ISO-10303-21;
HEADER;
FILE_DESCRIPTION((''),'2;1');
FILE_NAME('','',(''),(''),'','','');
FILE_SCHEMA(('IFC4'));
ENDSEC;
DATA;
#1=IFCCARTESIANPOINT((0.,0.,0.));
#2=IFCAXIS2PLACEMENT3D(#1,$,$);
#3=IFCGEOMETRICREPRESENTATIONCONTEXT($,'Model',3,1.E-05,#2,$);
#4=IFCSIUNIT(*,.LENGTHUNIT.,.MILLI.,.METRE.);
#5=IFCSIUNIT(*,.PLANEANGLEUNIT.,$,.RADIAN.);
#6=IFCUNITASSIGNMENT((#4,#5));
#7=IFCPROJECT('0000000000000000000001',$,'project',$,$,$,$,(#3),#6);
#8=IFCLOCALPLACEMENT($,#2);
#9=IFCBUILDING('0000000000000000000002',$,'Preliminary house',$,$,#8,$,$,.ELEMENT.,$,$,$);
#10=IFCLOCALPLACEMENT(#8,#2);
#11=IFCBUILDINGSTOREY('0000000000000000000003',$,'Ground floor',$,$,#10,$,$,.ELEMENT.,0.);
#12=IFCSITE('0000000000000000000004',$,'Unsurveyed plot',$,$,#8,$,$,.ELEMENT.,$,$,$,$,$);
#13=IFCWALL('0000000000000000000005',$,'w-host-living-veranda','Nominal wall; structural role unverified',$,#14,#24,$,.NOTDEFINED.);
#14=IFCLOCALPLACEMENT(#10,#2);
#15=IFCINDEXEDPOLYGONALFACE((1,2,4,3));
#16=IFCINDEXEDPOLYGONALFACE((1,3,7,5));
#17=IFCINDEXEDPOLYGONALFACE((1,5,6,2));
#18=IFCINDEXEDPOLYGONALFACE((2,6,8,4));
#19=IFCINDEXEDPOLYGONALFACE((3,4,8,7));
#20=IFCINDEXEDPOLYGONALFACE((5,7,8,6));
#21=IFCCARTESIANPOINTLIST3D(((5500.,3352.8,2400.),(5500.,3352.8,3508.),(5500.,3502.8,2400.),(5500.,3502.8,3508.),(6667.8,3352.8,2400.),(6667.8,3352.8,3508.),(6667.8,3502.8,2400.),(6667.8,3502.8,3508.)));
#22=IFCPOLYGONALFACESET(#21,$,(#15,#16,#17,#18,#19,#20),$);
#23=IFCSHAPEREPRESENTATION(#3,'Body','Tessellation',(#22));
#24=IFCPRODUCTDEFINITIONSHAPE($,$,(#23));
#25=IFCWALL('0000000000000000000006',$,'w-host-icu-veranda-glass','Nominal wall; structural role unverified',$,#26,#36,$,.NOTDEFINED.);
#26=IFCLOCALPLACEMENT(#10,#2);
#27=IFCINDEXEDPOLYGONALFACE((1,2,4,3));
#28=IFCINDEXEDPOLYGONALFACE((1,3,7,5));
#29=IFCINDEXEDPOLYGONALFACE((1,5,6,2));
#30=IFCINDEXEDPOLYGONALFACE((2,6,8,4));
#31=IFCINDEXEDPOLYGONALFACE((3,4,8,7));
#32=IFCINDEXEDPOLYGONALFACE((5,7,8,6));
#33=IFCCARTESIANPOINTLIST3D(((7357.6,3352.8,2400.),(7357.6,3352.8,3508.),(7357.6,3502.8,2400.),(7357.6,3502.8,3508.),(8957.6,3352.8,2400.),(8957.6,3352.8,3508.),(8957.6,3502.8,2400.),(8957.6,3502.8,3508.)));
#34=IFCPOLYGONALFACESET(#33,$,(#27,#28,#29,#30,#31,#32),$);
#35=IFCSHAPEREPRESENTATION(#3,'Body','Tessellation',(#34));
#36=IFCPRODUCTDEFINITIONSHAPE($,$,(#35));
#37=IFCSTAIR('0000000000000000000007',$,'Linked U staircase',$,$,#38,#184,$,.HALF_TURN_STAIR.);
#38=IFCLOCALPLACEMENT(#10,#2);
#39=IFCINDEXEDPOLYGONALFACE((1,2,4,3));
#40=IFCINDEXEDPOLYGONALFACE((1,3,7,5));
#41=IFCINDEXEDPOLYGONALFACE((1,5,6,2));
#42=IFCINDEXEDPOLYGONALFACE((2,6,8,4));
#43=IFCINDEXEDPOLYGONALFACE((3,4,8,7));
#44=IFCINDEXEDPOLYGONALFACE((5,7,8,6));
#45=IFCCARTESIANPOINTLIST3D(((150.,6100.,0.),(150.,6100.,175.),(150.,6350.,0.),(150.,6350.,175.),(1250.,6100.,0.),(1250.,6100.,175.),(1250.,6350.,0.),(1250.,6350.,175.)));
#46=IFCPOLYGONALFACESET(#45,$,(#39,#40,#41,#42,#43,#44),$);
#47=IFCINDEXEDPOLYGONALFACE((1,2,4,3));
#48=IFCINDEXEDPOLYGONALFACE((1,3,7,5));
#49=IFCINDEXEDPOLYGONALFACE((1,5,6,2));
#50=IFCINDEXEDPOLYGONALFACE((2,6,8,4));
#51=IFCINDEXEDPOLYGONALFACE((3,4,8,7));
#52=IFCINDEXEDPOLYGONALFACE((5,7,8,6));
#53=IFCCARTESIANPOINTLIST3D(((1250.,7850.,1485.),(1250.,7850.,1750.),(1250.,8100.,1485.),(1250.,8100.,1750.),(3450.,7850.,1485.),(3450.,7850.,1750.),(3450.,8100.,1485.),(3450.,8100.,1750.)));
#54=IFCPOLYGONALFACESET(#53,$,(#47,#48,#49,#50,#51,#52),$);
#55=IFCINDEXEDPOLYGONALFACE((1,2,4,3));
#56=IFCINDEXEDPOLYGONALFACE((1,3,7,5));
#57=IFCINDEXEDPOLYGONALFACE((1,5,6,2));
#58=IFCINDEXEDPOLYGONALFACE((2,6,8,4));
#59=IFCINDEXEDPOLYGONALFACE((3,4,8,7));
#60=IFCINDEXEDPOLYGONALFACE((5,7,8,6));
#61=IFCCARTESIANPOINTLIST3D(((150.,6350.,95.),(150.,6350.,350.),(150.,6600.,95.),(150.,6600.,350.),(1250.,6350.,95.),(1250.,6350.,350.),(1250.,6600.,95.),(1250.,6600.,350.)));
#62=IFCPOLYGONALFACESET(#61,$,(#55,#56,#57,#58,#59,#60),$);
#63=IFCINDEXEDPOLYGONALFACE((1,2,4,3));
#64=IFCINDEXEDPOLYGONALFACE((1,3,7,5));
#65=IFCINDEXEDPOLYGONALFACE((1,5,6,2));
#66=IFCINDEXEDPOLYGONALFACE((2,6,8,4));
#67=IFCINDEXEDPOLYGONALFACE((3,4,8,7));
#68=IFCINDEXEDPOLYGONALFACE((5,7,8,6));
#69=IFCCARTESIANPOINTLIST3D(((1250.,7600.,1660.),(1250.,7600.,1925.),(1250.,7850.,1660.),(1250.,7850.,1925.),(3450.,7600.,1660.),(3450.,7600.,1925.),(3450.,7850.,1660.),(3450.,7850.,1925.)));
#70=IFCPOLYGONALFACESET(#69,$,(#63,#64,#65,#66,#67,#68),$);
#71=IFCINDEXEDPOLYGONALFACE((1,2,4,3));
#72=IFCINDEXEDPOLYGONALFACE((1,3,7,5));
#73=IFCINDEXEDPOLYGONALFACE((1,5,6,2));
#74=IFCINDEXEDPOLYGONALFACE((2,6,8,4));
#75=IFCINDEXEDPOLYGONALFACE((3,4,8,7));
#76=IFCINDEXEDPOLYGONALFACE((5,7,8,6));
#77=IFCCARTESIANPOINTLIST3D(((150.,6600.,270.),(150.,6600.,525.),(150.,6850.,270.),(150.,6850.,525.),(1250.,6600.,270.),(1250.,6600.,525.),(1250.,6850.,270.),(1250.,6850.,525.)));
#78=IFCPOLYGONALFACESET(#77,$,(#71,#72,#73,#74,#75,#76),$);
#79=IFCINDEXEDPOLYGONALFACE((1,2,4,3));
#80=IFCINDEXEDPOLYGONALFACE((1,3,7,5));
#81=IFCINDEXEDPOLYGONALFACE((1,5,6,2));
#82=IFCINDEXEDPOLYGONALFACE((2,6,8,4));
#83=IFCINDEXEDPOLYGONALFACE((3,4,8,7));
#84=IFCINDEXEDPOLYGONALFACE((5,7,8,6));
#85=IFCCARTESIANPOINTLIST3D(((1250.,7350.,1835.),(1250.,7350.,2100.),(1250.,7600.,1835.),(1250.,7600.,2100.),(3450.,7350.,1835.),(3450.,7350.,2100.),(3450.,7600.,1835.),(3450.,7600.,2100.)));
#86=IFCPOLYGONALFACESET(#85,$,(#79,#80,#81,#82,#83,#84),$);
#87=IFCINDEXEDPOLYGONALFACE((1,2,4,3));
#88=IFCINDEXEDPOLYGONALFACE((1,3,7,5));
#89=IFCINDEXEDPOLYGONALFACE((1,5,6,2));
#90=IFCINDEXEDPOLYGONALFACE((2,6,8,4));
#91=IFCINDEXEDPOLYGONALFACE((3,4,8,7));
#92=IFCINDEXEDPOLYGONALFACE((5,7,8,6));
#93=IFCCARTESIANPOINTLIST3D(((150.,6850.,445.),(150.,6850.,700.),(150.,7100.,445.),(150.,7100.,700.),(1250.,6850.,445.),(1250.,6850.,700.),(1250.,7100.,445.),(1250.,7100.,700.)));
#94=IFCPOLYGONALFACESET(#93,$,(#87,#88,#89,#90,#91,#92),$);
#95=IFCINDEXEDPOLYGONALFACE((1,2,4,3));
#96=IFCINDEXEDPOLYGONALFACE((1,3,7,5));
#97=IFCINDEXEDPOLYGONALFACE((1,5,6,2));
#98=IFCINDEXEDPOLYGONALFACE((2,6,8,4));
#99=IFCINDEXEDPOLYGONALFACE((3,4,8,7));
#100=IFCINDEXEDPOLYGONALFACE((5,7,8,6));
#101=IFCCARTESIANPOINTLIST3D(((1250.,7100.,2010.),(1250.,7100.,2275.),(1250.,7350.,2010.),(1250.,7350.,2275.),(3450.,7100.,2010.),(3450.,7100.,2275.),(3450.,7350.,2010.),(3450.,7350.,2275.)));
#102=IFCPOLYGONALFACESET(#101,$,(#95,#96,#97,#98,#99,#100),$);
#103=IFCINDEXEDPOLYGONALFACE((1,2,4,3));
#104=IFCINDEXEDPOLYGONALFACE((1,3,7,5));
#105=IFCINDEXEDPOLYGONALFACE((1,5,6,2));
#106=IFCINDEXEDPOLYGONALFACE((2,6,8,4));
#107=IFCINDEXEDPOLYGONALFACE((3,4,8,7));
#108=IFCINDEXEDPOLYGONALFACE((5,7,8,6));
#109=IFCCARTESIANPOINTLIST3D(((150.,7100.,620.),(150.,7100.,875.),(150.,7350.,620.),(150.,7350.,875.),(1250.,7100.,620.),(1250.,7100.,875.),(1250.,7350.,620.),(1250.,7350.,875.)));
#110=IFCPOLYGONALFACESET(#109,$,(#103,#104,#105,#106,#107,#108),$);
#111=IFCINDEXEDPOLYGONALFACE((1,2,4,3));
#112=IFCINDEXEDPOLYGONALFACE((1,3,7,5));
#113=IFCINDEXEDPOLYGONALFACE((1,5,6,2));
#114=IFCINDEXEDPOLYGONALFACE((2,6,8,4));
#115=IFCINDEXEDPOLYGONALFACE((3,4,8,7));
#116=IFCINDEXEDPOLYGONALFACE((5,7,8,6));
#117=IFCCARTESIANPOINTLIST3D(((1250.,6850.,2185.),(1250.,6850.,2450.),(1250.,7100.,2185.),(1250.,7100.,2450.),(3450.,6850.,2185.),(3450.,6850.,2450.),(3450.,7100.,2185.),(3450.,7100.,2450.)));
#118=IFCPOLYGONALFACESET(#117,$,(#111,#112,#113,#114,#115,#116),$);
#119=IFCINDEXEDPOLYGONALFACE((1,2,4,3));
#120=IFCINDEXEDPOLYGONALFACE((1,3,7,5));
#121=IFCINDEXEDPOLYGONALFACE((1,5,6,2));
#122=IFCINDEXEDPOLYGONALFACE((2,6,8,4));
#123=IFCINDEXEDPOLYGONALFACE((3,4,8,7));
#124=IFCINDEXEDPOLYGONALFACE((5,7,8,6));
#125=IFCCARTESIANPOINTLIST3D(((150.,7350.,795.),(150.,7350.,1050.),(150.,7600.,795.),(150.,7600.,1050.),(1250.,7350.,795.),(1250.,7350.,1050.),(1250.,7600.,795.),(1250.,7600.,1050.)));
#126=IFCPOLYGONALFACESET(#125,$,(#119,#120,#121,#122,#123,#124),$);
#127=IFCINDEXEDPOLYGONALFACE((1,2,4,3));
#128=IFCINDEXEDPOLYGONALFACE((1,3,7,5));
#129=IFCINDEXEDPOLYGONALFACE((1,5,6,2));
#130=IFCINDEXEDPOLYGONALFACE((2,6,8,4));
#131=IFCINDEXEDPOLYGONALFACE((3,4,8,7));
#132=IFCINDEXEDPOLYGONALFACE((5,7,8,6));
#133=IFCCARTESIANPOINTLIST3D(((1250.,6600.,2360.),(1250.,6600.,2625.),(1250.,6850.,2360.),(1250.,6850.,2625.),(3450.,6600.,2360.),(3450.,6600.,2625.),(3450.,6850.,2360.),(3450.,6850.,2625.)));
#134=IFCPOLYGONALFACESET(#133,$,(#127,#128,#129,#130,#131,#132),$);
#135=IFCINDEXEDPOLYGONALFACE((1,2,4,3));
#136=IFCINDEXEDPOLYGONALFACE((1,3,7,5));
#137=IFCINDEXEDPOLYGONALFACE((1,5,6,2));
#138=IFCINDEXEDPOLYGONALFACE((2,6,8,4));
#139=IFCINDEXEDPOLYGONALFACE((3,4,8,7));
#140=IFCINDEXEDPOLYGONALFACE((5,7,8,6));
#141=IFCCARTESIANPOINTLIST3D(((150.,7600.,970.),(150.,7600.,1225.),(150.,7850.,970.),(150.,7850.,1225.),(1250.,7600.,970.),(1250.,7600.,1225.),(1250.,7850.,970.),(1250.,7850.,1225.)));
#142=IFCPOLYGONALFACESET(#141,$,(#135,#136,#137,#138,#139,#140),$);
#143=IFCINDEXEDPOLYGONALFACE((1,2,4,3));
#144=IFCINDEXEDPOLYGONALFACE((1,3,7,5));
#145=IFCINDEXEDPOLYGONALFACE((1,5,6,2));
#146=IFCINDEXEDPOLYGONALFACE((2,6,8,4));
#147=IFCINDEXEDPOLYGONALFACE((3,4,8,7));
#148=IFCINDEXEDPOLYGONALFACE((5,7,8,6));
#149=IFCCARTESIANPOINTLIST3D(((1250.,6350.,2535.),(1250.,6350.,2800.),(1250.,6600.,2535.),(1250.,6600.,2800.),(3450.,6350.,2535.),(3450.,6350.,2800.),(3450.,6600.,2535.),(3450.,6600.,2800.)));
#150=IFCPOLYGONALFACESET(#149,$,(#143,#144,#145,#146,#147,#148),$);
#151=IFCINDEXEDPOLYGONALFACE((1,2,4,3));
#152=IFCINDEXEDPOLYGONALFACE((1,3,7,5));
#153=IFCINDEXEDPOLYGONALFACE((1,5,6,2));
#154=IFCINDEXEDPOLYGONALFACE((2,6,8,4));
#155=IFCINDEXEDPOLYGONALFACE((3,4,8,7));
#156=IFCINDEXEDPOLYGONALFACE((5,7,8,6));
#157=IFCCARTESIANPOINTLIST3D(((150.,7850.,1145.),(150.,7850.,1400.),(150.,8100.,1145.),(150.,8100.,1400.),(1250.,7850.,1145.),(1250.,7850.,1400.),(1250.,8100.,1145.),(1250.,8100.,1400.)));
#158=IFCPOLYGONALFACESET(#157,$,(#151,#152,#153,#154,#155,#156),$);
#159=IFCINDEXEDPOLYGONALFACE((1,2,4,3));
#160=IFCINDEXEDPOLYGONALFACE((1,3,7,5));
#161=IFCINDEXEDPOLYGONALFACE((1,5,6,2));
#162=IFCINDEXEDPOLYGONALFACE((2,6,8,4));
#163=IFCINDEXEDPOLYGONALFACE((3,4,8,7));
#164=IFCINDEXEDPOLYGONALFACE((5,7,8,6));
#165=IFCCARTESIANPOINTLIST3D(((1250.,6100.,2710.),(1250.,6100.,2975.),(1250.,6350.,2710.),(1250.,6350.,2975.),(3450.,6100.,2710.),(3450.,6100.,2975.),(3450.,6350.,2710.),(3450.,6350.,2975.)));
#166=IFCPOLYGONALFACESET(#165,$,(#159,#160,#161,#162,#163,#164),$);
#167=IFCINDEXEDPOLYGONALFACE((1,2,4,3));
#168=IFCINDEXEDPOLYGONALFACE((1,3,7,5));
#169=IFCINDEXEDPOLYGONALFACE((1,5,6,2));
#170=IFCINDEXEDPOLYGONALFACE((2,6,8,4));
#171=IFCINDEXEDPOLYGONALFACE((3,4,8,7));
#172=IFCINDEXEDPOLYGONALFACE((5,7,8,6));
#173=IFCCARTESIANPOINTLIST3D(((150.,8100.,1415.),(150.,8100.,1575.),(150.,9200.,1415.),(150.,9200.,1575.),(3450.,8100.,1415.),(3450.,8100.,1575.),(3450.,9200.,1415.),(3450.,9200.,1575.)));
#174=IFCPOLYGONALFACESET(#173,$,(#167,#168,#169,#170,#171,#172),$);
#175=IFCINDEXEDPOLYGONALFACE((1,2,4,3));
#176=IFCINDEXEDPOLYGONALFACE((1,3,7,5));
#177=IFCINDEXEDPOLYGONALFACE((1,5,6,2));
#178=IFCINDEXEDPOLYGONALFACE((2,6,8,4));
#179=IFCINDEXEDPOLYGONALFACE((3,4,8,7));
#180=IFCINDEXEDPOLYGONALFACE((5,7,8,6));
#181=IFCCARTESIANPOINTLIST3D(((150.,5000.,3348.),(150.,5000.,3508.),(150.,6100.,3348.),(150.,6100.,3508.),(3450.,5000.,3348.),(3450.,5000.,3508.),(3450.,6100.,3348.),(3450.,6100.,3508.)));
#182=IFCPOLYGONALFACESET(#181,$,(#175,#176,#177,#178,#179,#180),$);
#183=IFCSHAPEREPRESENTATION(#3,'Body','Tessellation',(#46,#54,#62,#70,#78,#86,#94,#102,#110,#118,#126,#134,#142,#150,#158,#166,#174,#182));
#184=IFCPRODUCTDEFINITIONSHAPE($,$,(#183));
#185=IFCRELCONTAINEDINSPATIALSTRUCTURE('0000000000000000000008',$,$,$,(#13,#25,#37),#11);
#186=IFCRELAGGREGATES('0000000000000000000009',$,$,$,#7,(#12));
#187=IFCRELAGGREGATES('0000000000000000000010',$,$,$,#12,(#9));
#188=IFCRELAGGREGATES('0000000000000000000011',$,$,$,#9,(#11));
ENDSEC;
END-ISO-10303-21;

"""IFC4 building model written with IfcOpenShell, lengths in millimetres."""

from ifc_helpers import new_model, si_unit, frame, origin, place, context, project, spatial, polyline, outline, extrude, element, save


model = new_model("IFC4")

# Units and contexts
model_context = context("Model", 3, precision=1e-05, world=origin())
ifc_project = project(units=[si_unit("LENGTHUNIT", "METRE", prefix="MILLI"), si_unit("PLANEANGLEUNIT", "RADIAN")], contexts=[model_context])

# Site, building, storey
placement_1 = place(None, origin())
site = spatial("IfcSite", under=ifc_project, at=placement_1, Name="Unsurveyed plot", CompositionType="ELEMENT")
building = spatial("IfcBuilding", under=site, at=placement_1, Name="Preliminary house", CompositionType="ELEMENT")
placement_2 = place(placement_1, origin())
storey = spatial("IfcBuildingStorey", under=building, at=placement_2, Name="Ground floor", CompositionType="ELEMENT", Elevation=0.0)

# Walls, openings
wall_1 = element("IfcWall", 1, at=placement_2, inside=storey, Name="w-host-living-veranda", Description="Nominal wall; structural role unverified", PredefinedType="NOTDEFINED", context=model_context, shape_type="SweptSolid", body=[
    extrude(outline(polyline([(5500.0, 3352.8), (6667.8, 3352.8), (6667.8, 3502.8), (5500.0, 3502.8), (5500.0, 3352.8)])), origin(), (0.0, 0.0, 1.0), 3508.0),
])
element("IfcOpeningElement", 2, at=placement_2, cuts=wall_1, PredefinedType="OPENING", context=model_context, shape_type="SweptSolid", body=[
    extrude(outline(polyline([(5500.0, 2977.8), (6667.8, 2977.8), (6667.8, 3877.8), (5500.0, 3877.8), (5500.0, 2977.8)])), origin(), (0.0, 0.0, 1.0), 2400.0),
])
wall_2 = element("IfcWall", 3, at=placement_2, inside=storey, Name="w-host-icu-veranda-glass", Description="Nominal wall; structural role unverified", PredefinedType="NOTDEFINED", context=model_context, shape_type="SweptSolid", body=[
    extrude(outline(polyline([(7357.6, 3352.8), (8957.6, 3352.8), (8957.6, 3502.8), (7357.6, 3502.8), (7357.6, 3352.8)])), origin(), (0.0, 0.0, 1.0), 3508.0),
])
element("IfcOpeningElement", 4, at=placement_2, cuts=wall_2, PredefinedType="OPENING", context=model_context, shape_type="SweptSolid", body=[
    extrude(outline(polyline([(7357.6, 2977.8), (8957.6, 2977.8), (8957.6, 3877.8), (7357.6, 3877.8), (7357.6, 2977.8)])), origin(), (0.0, 0.0, 1.0), 2400.0),
])

# Stair
element("IfcStair", 5, at=placement_2, inside=storey, Name="Linked U staircase", PredefinedType="HALF_TURN_STAIR", context=model_context, shape_type="SweptSolid", body=[
    extrude(outline(polyline([(1250.0, 6100.0), (1250.0, 6350.0), (150.0, 6350.0), (150.0, 6100.0), (1250.0, 6100.0)])), origin(), (0.0, 0.0, 1.0), 175.0),
    extrude(outline(polyline([(3450.0, 7850.0), (3450.0, 8100.0), (1250.0, 8100.0), (1250.0, 7850.0), (3450.0, 7850.0)])), frame((0.0, 0.0, 1485.0)), (0.0, 0.0, 1.0), 265.0),
    extrude(outline(polyline([(1250.0, 6350.0), (1250.0, 6600.0), (150.0, 6600.0), (150.0, 6350.0), (1250.0, 6350.0)])), frame((0.0, 0.0, 95.0)), (0.0, 0.0, 1.0), 255.0),
    extrude(outline(polyline([(3450.0, 7600.0), (3450.0, 7850.0), (1250.0, 7850.0), (1250.0, 7600.0), (3450.0, 7600.0)])), frame((0.0, 0.0, 1660.0)), (0.0, 0.0, 1.0), 265.0),
    extrude(outline(polyline([(1250.0, 6600.0), (1250.0, 6850.0), (150.0, 6850.0), (150.0, 6600.0), (1250.0, 6600.0)])), frame((0.0, 0.0, 270.0)), (0.0, 0.0, 1.0), 255.0),
    extrude(outline(polyline([(3450.0, 7350.0), (3450.0, 7600.0), (1250.0, 7600.0), (1250.0, 7350.0), (3450.0, 7350.0)])), frame((0.0, 0.0, 1835.0)), (0.0, 0.0, 1.0), 265.0),
    extrude(outline(polyline([(1250.0, 6850.0), (1250.0, 7100.0), (150.0, 7100.0), (150.0, 6850.0), (1250.0, 6850.0)])), frame((0.0, 0.0, 445.0)), (0.0, 0.0, 1.0), 255.0),
    extrude(outline(polyline([(3450.0, 7100.0), (3450.0, 7350.0), (1250.0, 7350.0), (1250.0, 7100.0), (3450.0, 7100.0)])), frame((0.0, 0.0, 2010.0)), (0.0, 0.0, 1.0), 265.0),
    extrude(outline(polyline([(1250.0, 7100.0), (1250.0, 7350.0), (150.0, 7350.0), (150.0, 7100.0), (1250.0, 7100.0)])), frame((0.0, 0.0, 620.0)), (0.0, 0.0, 1.0), 255.0),
    extrude(outline(polyline([(3450.0, 6850.0), (3450.0, 7100.0), (1250.0, 7100.0), (1250.0, 6850.0), (3450.0, 6850.0)])), frame((0.0, 0.0, 2185.0)), (0.0, 0.0, 1.0), 265.0),
    extrude(outline(polyline([(1250.0, 7350.0), (1250.0, 7600.0), (150.0, 7600.0), (150.0, 7350.0), (1250.0, 7350.0)])), frame((0.0, 0.0, 795.0)), (0.0, 0.0, 1.0), 255.0),
    extrude(outline(polyline([(3450.0, 6600.0), (3450.0, 6850.0), (1250.0, 6850.0), (1250.0, 6600.0), (3450.0, 6600.0)])), frame((0.0, 0.0, 2360.0)), (0.0, 0.0, 1.0), 265.0),
    extrude(outline(polyline([(1250.0, 7600.0), (1250.0, 7850.0), (150.0, 7850.0), (150.0, 7600.0), (1250.0, 7600.0)])), frame((0.0, 0.0, 970.0)), (0.0, 0.0, 1.0), 255.0),
    extrude(outline(polyline([(3450.0, 6350.0), (3450.0, 6600.0), (1250.0, 6600.0), (1250.0, 6350.0), (3450.0, 6350.0)])), frame((0.0, 0.0, 2535.0)), (0.0, 0.0, 1.0), 265.0),
    extrude(outline(polyline([(1250.0, 7850.0), (1250.0, 8100.0), (150.0, 8100.0), (150.0, 7850.0), (1250.0, 7850.0)])), frame((0.0, 0.0, 1145.0)), (0.0, 0.0, 1.0), 255.0),
    extrude(outline(polyline([(3450.0, 6100.0), (3450.0, 6350.0), (1250.0, 6350.0), (1250.0, 6100.0), (3450.0, 6100.0)])), frame((0.0, 0.0, 2710.0)), (0.0, 0.0, 1.0), 265.0),
    extrude(outline(polyline([(3450.0, 8100.0), (3450.0, 9200.0), (150.0, 9200.0), (150.0, 8100.0), (3450.0, 8100.0)])), frame((0.0, 0.0, 1415.0)), (0.0, 0.0, 1.0), 160.0),
    extrude(outline(polyline([(3450.0, 5000.0), (3450.0, 6100.0), (150.0, 6100.0), (150.0, 5000.0), (3450.0, 5000.0)])), frame((0.0, 0.0, 3348.0)), (0.0, 0.0, 1.0), 160.0),
])

save(model, "model.ifc")
